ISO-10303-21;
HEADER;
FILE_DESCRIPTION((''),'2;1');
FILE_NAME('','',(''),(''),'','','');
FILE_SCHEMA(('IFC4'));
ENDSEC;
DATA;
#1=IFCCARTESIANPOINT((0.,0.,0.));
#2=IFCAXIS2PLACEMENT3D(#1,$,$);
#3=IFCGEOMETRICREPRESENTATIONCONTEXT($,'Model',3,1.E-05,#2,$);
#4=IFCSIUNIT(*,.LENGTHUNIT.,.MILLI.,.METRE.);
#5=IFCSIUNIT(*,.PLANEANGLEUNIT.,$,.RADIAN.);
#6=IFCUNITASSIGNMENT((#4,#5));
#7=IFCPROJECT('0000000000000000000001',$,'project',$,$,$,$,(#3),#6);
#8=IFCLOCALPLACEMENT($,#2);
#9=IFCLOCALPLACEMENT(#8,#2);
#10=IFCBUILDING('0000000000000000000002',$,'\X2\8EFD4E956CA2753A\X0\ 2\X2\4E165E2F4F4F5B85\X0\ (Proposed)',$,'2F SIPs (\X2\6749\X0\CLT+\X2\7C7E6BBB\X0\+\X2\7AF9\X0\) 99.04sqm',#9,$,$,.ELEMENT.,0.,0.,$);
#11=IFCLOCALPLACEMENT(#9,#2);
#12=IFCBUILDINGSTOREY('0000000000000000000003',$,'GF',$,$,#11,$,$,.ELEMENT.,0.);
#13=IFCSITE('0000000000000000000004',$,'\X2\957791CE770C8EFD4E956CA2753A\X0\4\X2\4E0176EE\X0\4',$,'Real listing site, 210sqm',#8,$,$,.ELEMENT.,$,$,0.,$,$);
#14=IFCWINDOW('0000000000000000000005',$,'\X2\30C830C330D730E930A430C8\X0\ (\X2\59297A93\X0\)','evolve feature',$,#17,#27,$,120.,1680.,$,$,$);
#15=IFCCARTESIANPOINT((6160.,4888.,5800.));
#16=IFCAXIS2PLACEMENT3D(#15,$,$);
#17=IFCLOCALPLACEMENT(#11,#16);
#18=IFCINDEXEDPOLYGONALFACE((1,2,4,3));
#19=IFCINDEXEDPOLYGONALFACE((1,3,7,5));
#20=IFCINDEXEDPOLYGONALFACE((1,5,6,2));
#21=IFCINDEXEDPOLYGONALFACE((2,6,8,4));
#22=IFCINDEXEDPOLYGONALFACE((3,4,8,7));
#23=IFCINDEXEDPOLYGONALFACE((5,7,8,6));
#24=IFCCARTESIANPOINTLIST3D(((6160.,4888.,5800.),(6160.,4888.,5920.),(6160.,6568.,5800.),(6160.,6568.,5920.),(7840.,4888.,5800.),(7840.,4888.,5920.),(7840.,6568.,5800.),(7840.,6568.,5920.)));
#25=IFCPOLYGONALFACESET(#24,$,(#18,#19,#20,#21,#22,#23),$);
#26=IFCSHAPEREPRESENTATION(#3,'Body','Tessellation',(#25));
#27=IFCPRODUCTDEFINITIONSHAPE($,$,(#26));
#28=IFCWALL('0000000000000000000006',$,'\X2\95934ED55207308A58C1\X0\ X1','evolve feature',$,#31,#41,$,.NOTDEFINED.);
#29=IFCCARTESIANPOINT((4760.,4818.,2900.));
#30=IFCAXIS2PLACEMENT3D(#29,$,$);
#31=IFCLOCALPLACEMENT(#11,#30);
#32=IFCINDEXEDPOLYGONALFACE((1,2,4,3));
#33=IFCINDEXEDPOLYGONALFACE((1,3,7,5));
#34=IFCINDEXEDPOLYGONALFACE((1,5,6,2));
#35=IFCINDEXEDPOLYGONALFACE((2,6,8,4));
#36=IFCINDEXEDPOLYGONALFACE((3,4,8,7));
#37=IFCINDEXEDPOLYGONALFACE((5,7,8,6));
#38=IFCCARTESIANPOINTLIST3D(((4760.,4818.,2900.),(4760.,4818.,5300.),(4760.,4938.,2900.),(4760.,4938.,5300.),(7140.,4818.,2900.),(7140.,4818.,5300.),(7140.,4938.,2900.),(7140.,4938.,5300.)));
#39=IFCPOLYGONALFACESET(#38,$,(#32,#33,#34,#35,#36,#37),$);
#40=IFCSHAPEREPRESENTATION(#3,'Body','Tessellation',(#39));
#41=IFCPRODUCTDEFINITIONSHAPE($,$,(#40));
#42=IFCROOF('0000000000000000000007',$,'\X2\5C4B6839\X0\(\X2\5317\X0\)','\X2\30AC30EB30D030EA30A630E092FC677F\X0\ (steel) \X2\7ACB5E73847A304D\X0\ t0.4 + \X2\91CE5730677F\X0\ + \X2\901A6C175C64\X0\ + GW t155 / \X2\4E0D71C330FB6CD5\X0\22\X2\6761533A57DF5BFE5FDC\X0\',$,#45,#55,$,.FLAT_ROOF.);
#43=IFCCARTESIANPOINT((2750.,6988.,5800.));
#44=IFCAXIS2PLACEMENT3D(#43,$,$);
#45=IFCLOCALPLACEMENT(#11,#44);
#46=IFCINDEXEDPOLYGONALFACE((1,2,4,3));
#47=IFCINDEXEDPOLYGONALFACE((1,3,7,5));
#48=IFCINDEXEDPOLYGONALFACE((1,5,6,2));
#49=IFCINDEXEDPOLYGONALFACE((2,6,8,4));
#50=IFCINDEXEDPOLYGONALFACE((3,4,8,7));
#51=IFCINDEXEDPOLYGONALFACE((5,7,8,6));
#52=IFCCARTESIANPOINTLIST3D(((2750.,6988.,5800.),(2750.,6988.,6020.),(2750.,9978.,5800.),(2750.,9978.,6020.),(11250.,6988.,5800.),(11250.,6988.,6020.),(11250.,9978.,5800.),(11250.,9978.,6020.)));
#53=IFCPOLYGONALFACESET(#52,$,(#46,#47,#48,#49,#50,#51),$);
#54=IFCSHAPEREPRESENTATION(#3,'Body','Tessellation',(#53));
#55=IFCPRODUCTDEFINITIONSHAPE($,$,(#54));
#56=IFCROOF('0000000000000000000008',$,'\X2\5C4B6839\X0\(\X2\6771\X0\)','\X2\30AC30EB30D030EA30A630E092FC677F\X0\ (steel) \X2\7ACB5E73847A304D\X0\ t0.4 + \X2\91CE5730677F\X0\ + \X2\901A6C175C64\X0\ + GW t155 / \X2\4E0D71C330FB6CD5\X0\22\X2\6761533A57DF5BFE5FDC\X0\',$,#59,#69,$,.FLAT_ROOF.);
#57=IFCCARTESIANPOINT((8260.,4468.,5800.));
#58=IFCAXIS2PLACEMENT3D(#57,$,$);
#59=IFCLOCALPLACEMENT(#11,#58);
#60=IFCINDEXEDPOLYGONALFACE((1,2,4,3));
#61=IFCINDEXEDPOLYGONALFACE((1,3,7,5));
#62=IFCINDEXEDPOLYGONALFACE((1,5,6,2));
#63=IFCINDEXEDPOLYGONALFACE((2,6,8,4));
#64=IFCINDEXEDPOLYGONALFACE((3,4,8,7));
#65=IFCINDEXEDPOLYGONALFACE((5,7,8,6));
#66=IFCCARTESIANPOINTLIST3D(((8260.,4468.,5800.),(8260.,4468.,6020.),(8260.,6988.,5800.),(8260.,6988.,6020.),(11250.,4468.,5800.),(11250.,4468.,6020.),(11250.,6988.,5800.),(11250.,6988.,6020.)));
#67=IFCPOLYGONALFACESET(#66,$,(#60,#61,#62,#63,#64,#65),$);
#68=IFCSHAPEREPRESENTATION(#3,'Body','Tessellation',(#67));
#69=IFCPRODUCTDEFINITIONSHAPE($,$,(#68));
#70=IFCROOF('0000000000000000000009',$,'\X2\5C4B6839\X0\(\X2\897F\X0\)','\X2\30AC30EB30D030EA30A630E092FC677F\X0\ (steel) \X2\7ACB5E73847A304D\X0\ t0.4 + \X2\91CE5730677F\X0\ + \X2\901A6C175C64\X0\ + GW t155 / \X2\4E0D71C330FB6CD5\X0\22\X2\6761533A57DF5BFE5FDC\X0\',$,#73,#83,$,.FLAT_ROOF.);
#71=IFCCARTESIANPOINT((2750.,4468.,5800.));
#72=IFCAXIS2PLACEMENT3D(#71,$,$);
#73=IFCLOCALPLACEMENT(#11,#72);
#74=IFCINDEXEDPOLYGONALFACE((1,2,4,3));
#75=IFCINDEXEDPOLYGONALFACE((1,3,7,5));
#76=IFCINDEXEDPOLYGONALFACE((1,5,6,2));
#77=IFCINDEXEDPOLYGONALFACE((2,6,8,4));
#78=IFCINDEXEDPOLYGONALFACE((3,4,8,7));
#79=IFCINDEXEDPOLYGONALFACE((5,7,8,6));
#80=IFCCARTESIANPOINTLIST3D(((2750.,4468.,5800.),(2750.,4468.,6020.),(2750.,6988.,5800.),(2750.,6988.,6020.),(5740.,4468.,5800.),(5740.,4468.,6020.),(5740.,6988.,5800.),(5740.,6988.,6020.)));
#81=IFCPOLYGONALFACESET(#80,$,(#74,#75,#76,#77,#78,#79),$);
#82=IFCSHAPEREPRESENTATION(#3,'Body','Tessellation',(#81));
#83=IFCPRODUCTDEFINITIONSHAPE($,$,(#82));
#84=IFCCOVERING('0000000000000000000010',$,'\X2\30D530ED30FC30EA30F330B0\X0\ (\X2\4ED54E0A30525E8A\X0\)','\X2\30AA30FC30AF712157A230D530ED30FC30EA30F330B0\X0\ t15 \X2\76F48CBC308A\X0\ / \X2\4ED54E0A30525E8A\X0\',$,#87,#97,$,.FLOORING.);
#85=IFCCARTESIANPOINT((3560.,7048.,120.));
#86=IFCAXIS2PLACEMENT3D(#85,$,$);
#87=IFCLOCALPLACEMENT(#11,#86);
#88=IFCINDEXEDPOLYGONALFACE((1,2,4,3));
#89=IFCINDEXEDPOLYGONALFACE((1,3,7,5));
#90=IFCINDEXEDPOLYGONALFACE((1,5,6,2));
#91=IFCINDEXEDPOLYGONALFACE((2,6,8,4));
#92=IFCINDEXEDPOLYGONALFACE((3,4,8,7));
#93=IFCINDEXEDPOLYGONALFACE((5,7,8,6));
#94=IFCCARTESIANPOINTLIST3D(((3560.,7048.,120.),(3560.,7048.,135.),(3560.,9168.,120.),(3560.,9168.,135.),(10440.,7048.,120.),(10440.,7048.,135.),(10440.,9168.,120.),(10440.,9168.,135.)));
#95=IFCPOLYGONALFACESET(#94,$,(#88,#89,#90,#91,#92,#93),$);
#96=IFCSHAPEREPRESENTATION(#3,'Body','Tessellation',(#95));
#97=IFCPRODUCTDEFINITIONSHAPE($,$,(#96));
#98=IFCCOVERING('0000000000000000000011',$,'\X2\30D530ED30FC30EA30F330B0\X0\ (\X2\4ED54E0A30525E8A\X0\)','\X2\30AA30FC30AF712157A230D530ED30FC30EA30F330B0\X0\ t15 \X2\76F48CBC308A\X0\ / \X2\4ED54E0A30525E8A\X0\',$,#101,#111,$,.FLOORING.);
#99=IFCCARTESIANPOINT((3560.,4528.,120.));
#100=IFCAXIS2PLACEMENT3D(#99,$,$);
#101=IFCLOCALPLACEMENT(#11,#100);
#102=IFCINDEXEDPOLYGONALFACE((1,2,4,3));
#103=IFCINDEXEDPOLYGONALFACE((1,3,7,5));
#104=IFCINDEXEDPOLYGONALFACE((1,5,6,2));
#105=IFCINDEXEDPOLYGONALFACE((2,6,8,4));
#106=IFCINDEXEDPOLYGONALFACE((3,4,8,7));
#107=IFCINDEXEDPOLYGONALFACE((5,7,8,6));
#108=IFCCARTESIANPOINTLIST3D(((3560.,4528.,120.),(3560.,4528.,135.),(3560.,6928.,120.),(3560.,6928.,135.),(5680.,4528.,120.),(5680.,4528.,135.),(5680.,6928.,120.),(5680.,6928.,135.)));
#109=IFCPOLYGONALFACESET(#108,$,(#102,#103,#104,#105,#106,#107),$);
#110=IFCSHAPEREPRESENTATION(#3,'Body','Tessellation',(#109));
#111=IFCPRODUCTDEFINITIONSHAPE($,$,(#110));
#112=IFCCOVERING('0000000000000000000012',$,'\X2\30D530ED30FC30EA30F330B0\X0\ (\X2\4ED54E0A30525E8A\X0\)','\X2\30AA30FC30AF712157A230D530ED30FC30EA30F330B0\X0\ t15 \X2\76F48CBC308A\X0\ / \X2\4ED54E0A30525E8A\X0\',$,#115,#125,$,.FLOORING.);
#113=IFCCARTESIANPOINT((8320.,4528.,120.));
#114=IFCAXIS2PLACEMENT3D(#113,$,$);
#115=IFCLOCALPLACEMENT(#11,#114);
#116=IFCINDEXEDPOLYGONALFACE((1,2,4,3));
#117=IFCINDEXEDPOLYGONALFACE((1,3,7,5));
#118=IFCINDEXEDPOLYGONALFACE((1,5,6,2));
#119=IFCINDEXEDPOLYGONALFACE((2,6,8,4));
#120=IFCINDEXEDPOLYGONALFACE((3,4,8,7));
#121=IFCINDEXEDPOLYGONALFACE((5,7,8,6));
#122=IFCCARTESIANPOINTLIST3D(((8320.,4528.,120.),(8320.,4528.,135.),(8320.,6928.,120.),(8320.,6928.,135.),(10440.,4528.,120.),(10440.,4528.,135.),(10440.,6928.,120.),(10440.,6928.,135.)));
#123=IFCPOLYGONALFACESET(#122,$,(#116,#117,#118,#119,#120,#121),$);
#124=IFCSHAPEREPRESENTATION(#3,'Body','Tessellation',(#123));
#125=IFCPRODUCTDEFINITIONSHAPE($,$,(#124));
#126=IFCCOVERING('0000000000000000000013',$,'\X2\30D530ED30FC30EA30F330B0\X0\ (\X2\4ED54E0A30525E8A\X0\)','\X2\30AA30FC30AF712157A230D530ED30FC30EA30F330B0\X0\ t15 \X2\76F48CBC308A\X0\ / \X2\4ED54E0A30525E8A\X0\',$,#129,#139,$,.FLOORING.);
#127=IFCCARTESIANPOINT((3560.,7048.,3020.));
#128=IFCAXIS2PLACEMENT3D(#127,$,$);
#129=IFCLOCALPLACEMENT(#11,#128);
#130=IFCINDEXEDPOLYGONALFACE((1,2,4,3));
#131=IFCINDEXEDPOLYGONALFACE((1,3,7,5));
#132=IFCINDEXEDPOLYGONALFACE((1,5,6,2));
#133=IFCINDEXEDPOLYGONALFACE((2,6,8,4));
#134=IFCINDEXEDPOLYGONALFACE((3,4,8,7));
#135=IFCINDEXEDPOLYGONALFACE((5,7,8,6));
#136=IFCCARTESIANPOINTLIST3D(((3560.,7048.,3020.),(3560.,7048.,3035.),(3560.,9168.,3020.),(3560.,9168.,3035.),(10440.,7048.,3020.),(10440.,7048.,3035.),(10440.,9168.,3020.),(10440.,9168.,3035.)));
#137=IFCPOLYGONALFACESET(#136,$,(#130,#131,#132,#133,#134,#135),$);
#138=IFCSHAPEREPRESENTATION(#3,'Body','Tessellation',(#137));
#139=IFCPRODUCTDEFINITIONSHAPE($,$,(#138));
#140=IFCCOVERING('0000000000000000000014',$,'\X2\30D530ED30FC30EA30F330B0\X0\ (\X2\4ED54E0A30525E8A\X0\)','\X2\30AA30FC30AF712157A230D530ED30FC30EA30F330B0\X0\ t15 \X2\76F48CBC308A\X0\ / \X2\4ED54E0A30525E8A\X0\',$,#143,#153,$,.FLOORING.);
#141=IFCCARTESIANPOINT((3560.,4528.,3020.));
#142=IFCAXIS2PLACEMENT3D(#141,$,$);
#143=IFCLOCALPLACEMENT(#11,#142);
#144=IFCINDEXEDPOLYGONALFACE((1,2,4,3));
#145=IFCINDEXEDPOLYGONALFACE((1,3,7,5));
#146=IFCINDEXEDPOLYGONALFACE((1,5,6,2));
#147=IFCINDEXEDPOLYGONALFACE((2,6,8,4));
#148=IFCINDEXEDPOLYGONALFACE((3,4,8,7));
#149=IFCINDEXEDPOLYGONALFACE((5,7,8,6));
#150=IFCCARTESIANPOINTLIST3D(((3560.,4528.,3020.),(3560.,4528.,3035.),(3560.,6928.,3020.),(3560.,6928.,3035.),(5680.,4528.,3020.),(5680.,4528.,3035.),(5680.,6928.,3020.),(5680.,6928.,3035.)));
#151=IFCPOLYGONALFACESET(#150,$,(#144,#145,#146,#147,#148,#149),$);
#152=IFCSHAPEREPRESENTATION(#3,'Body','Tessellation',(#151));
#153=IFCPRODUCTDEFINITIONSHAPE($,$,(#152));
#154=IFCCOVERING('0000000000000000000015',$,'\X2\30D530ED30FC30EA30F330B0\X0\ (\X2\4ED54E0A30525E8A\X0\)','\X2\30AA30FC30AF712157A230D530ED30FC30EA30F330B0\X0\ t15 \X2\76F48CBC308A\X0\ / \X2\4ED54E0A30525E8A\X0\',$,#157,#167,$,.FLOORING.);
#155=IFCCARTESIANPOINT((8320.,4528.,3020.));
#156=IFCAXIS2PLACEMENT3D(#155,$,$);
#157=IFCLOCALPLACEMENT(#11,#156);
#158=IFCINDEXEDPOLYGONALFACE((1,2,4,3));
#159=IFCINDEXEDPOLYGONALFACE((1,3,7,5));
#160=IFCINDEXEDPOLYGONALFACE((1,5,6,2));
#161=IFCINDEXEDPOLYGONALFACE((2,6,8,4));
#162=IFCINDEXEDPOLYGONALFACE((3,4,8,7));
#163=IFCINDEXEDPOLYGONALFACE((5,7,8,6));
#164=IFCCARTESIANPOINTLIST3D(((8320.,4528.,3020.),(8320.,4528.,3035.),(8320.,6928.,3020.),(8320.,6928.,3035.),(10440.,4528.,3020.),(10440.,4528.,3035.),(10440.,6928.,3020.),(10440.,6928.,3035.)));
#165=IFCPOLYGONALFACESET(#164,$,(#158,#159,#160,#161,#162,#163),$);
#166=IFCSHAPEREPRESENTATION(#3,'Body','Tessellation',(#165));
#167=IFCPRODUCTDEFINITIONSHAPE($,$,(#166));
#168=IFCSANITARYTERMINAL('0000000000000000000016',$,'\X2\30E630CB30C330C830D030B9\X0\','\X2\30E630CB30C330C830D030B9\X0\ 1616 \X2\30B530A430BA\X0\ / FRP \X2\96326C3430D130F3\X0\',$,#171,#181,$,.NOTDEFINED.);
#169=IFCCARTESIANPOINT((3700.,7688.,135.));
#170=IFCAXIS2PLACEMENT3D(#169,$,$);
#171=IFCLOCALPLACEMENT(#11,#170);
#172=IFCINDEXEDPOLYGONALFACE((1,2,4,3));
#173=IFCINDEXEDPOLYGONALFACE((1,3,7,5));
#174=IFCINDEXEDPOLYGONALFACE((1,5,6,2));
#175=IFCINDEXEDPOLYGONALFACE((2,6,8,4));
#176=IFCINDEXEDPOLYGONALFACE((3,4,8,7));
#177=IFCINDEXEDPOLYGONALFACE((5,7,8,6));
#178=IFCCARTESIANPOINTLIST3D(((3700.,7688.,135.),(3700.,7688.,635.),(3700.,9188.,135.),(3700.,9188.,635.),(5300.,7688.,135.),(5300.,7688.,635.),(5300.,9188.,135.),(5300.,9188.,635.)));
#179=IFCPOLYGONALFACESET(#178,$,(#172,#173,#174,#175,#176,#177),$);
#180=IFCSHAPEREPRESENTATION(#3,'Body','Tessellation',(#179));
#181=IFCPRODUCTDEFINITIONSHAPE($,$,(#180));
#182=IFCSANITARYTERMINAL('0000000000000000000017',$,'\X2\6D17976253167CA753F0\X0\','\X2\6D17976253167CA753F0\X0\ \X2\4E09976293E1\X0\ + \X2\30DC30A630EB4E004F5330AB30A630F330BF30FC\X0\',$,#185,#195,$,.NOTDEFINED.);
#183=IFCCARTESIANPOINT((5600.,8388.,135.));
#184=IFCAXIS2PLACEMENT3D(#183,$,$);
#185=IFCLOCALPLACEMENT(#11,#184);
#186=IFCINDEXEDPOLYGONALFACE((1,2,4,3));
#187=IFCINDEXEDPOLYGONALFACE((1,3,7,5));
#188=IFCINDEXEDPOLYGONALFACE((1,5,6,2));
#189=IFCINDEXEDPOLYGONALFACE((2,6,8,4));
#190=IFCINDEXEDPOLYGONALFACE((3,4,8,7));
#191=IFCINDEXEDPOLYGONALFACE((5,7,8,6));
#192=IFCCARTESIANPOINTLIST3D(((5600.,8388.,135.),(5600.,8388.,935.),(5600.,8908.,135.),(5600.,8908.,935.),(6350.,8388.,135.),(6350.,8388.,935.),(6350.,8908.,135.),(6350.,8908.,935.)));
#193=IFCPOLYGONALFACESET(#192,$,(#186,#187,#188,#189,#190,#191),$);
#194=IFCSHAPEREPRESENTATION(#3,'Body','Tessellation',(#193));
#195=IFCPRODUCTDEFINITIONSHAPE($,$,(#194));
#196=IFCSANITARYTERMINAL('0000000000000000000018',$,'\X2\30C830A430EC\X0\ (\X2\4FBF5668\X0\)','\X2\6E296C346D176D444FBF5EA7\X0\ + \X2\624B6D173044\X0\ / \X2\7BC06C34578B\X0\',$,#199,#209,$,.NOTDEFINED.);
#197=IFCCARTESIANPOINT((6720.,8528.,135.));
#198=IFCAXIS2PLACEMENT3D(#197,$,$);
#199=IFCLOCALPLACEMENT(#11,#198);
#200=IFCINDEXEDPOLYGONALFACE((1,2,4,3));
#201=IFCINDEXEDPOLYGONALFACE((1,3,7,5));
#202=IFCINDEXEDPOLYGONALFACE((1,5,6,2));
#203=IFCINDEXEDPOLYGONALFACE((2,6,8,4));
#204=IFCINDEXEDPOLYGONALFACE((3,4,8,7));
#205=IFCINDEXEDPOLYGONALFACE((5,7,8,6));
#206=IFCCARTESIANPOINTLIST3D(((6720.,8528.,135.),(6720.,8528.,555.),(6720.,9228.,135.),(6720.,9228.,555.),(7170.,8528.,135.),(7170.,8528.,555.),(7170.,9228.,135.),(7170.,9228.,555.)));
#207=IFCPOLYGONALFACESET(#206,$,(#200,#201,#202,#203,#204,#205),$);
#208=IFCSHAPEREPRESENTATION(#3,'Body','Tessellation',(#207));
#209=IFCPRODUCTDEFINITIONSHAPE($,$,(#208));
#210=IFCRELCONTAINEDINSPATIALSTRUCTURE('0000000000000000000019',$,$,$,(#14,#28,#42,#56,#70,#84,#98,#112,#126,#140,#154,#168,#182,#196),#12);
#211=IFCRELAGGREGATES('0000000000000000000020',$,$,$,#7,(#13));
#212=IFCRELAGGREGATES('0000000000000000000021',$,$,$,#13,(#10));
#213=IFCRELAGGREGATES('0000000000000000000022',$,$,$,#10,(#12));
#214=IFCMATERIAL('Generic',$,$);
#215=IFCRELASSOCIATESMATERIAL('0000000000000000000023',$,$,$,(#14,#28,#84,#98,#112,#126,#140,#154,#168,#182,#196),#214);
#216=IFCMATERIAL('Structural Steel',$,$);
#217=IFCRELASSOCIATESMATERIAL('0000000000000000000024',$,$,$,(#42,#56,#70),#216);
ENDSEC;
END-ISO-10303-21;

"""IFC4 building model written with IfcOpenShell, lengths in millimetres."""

from ifc_helpers import new_model, si_unit, frame, frame_2d, origin, place, context, project, spatial, rectangle, extrude, material, element, save


model = new_model("IFC4")

# Units and contexts
model_context = context("Model", 3, precision=1e-05, world=origin())
ifc_project = project(units=[si_unit("LENGTHUNIT", "METRE", prefix="MILLI"), si_unit("PLANEANGLEUNIT", "RADIAN")], contexts=[model_context])

# Site, building, storey
site_placement = place(None, origin())
site = spatial("IfcSite", under=ifc_project, at=site_placement, Name="長野県軽井沢町4丁目4", ObjectType="Real listing site, 210sqm", CompositionType="ELEMENT", RefElevation=0.0)
building_placement = place(site_placement, origin())
building = spatial("IfcBuilding", under=site, at=building_placement, Name="軽井沢町 2世帯住宅 (Proposed)", ObjectType="2F SIPs (杉CLT+籾殻+竹) 99.04sqm", CompositionType="ELEMENT", ElevationOfRefHeight=0.0, ElevationOfTerrain=0.0)
storey_placement = place(building_placement, origin())
storey = spatial("IfcBuildingStorey", under=building, at=storey_placement, Name="GF", CompositionType="ELEMENT", Elevation=0.0)

# Window
ifc_material_1 = material(Name="Generic")
window_1_placement = place(storey_placement, frame((6160.0, 4888.0, 5800.0)))
element("IfcWindow", 1, at=window_1_placement, inside=storey, material=ifc_material_1, Name="トップライト (天窓)", Description="evolve feature", OverallHeight=120.0, OverallWidth=1680.0, context=model_context, shape_type="SweptSolid", body=[
    extrude(rectangle(XDim=1680.0, YDim=1680.0, at=frame_2d((840.0, 840.0))), frame((6160.0, 4888.0, 5800.0)), (0.0, 0.0, 1.0), 120.0),
])

# Wall
wall_1_placement = place(storey_placement, frame((4760.0, 4818.0, 2900.0)))
element("IfcWall", 2, at=wall_1_placement, inside=storey, material=ifc_material_1, Name="間仕切り壁 X1", Description="evolve feature", PredefinedType="NOTDEFINED", context=model_context, shape_type="SweptSolid", body=[
    extrude(rectangle(XDim=2380.0, YDim=120.0, at=frame_2d((1190.0, 60.0))), frame((4760.0, 4818.0, 2900.0)), (0.0, 0.0, 1.0), 2400.0),
])

# Roofs
ifc_material_2 = material(Name="Structural Steel")
roof_1_placement = place(storey_placement, frame((2750.0, 6988.0, 5800.0)))
element("IfcRoof", 3, at=roof_1_placement, inside=storey, material=ifc_material_2, Name="屋根(北)", Description="ガルバリウム鋼板 (steel) 立平葺き t0.4 + 野地板 + 通気層 + GW t155 / 不燃・法22条区域対応", PredefinedType="FLAT_ROOF", context=model_context, shape_type="SweptSolid", body=[
    extrude(rectangle(XDim=8500.0, YDim=2990.0, at=frame_2d((4250.0, 1495.0))), frame((2750.0, 6988.0, 5800.0)), (0.0, 0.0, 1.0), 220.0),
])
roof_2_placement = place(storey_placement, frame((8260.0, 4468.0, 5800.0)))
element("IfcRoof", 4, at=roof_2_placement, inside=storey, material=ifc_material_2, Name="屋根(東)", Description="ガルバリウム鋼板 (steel) 立平葺き t0.4 + 野地板 + 通気層 + GW t155 / 不燃・法22条区域対応", PredefinedType="FLAT_ROOF", context=model_context, shape_type="SweptSolid", body=[
    extrude(rectangle(XDim=2990.0, YDim=2520.0, at=frame_2d((1495.0, 1260.0))), frame((8260.0, 4468.0, 5800.0)), (0.0, 0.0, 1.0), 220.0),
])
roof_3_placement = place(storey_placement, frame((2750.0, 4468.0, 5800.0)))
element("IfcRoof", 5, at=roof_3_placement, inside=storey, material=ifc_material_2, Name="屋根(西)", Description="ガルバリウム鋼板 (steel) 立平葺き t0.4 + 野地板 + 通気層 + GW t155 / 不燃・法22条区域対応", PredefinedType="FLAT_ROOF", context=model_context, shape_type="SweptSolid", body=[
    extrude(rectangle(XDim=2990.0, YDim=2520.0, at=frame_2d((1495.0, 1260.0))), frame((2750.0, 4468.0, 5800.0)), (0.0, 0.0, 1.0), 220.0),
])

# Coverings
covering_1_placement = place(storey_placement, frame((3560.0, 7048.0, 120.0)))
element("IfcCovering", 6, at=covering_1_placement, inside=storey, material=ifc_material_1, Name="フローリング (仕上げ床)", Description="オーク無垢フローリング t15 直貼り / 仕上げ床", PredefinedType="FLOORING", context=model_context, shape_type="SweptSolid", body=[
    extrude(rectangle(XDim=6880.0, YDim=2120.0, at=frame_2d((3440.0, 1060.0))), frame((3560.0, 7048.0, 120.0)), (0.0, 0.0, 1.0), 15.0),
])
covering_2_placement = place(storey_placement, frame((3560.0, 4528.0, 120.0)))
element("IfcCovering", 7, at=covering_2_placement, inside=storey, material=ifc_material_1, Name="フローリング (仕上げ床)", Description="オーク無垢フローリング t15 直貼り / 仕上げ床", PredefinedType="FLOORING", context=model_context, shape_type="SweptSolid", body=[
    extrude(rectangle(XDim=2120.0, YDim=2400.0, at=frame_2d((1060.0, 1200.0))), frame((3560.0, 4528.0, 120.0)), (0.0, 0.0, 1.0), 15.0),
])
covering_3_placement = place(storey_placement, frame((8320.0, 4528.0, 120.0)))
element("IfcCovering", 8, at=covering_3_placement, inside=storey, material=ifc_material_1, Name="フローリング (仕上げ床)", Description="オーク無垢フローリング t15 直貼り / 仕上げ床", PredefinedType="FLOORING", context=model_context, shape_type="SweptSolid", body=[
    extrude(rectangle(XDim=2120.0, YDim=2400.0, at=frame_2d((1060.0, 1200.0))), frame((8320.0, 4528.0, 120.0)), (0.0, 0.0, 1.0), 15.0),
])
covering_4_placement = place(storey_placement, frame((3560.0, 7048.0, 3020.0)))
element("IfcCovering", 9, at=covering_4_placement, inside=storey, material=ifc_material_1, Name="フローリング (仕上げ床)", Description="オーク無垢フローリング t15 直貼り / 仕上げ床", PredefinedType="FLOORING", context=model_context, shape_type="SweptSolid", body=[
    extrude(rectangle(XDim=6880.0, YDim=2120.0, at=frame_2d((3440.0, 1060.0))), frame((3560.0, 7048.0, 3020.0)), (0.0, 0.0, 1.0), 15.0),
])
covering_5_placement = place(storey_placement, frame((3560.0, 4528.0, 3020.0)))
element("IfcCovering", 10, at=covering_5_placement, inside=storey, material=ifc_material_1, Name="フローリング (仕上げ床)", Description="オーク無垢フローリング t15 直貼り / 仕上げ床", PredefinedType="FLOORING", context=model_context, shape_type="SweptSolid", body=[
    extrude(rectangle(XDim=2120.0, YDim=2400.0, at=frame_2d((1060.0, 1200.0))), frame((3560.0, 4528.0, 3020.0)), (0.0, 0.0, 1.0), 15.0),
])
covering_6_placement = place(storey_placement, frame((8320.0, 4528.0, 3020.0)))
element("IfcCovering", 11, at=covering_6_placement, inside=storey, material=ifc_material_1, Name="フローリング (仕上げ床)", Description="オーク無垢フローリング t15 直貼り / 仕上げ床", PredefinedType="FLOORING", context=model_context, shape_type="SweptSolid", body=[
    extrude(rectangle(XDim=2120.0, YDim=2400.0, at=frame_2d((1060.0, 1200.0))), frame((8320.0, 4528.0, 3020.0)), (0.0, 0.0, 1.0), 15.0),
])

# Sanitary terminals
sanitary_terminal_1_placement = place(storey_placement, frame((3700.0, 7688.0, 135.0)))
element("IfcSanitaryTerminal", 12, at=sanitary_terminal_1_placement, inside=storey, material=ifc_material_1, Name="ユニットバス", Description="ユニットバス 1616 サイズ / FRP 防水パン", PredefinedType="NOTDEFINED", context=model_context, shape_type="SweptSolid", body=[
    extrude(rectangle(XDim=1600.0, YDim=1500.0, at=frame_2d((800.0, 750.0))), frame((3700.0, 7688.0, 135.0)), (0.0, 0.0, 1.0), 500.0),
])
sanitary_terminal_2_placement = place(storey_placement, frame((5600.0, 8388.0, 135.0)))
element("IfcSanitaryTerminal", 13, at=sanitary_terminal_2_placement, inside=storey, material=ifc_material_1, Name="洗面化粧台", Description="洗面化粧台 三面鏡 + ボウル一体カウンター", PredefinedType="NOTDEFINED", context=model_context, shape_type="SweptSolid", body=[
    extrude(rectangle(XDim=750.0, YDim=520.0, at=frame_2d((375.0, 260.0))), frame((5600.0, 8388.0, 135.0)), (0.0, 0.0, 1.0), 800.0),
])
sanitary_terminal_3_placement = place(storey_placement, frame((6720.0, 8528.0, 135.0)))
element("IfcSanitaryTerminal", 14, at=sanitary_terminal_3_placement, inside=storey, material=ifc_material_1, Name="トイレ (便器)", Description="温水洗浄便座 + 手洗い / 節水型", PredefinedType="NOTDEFINED", context=model_context, shape_type="SweptSolid", body=[
    extrude(rectangle(XDim=450.0, YDim=700.0, at=frame_2d((225.0, 350.0))), frame((6720.0, 8528.0, 135.0)), (0.0, 0.0, 1.0), 420.0),
])

save(model, "model.ifc")
